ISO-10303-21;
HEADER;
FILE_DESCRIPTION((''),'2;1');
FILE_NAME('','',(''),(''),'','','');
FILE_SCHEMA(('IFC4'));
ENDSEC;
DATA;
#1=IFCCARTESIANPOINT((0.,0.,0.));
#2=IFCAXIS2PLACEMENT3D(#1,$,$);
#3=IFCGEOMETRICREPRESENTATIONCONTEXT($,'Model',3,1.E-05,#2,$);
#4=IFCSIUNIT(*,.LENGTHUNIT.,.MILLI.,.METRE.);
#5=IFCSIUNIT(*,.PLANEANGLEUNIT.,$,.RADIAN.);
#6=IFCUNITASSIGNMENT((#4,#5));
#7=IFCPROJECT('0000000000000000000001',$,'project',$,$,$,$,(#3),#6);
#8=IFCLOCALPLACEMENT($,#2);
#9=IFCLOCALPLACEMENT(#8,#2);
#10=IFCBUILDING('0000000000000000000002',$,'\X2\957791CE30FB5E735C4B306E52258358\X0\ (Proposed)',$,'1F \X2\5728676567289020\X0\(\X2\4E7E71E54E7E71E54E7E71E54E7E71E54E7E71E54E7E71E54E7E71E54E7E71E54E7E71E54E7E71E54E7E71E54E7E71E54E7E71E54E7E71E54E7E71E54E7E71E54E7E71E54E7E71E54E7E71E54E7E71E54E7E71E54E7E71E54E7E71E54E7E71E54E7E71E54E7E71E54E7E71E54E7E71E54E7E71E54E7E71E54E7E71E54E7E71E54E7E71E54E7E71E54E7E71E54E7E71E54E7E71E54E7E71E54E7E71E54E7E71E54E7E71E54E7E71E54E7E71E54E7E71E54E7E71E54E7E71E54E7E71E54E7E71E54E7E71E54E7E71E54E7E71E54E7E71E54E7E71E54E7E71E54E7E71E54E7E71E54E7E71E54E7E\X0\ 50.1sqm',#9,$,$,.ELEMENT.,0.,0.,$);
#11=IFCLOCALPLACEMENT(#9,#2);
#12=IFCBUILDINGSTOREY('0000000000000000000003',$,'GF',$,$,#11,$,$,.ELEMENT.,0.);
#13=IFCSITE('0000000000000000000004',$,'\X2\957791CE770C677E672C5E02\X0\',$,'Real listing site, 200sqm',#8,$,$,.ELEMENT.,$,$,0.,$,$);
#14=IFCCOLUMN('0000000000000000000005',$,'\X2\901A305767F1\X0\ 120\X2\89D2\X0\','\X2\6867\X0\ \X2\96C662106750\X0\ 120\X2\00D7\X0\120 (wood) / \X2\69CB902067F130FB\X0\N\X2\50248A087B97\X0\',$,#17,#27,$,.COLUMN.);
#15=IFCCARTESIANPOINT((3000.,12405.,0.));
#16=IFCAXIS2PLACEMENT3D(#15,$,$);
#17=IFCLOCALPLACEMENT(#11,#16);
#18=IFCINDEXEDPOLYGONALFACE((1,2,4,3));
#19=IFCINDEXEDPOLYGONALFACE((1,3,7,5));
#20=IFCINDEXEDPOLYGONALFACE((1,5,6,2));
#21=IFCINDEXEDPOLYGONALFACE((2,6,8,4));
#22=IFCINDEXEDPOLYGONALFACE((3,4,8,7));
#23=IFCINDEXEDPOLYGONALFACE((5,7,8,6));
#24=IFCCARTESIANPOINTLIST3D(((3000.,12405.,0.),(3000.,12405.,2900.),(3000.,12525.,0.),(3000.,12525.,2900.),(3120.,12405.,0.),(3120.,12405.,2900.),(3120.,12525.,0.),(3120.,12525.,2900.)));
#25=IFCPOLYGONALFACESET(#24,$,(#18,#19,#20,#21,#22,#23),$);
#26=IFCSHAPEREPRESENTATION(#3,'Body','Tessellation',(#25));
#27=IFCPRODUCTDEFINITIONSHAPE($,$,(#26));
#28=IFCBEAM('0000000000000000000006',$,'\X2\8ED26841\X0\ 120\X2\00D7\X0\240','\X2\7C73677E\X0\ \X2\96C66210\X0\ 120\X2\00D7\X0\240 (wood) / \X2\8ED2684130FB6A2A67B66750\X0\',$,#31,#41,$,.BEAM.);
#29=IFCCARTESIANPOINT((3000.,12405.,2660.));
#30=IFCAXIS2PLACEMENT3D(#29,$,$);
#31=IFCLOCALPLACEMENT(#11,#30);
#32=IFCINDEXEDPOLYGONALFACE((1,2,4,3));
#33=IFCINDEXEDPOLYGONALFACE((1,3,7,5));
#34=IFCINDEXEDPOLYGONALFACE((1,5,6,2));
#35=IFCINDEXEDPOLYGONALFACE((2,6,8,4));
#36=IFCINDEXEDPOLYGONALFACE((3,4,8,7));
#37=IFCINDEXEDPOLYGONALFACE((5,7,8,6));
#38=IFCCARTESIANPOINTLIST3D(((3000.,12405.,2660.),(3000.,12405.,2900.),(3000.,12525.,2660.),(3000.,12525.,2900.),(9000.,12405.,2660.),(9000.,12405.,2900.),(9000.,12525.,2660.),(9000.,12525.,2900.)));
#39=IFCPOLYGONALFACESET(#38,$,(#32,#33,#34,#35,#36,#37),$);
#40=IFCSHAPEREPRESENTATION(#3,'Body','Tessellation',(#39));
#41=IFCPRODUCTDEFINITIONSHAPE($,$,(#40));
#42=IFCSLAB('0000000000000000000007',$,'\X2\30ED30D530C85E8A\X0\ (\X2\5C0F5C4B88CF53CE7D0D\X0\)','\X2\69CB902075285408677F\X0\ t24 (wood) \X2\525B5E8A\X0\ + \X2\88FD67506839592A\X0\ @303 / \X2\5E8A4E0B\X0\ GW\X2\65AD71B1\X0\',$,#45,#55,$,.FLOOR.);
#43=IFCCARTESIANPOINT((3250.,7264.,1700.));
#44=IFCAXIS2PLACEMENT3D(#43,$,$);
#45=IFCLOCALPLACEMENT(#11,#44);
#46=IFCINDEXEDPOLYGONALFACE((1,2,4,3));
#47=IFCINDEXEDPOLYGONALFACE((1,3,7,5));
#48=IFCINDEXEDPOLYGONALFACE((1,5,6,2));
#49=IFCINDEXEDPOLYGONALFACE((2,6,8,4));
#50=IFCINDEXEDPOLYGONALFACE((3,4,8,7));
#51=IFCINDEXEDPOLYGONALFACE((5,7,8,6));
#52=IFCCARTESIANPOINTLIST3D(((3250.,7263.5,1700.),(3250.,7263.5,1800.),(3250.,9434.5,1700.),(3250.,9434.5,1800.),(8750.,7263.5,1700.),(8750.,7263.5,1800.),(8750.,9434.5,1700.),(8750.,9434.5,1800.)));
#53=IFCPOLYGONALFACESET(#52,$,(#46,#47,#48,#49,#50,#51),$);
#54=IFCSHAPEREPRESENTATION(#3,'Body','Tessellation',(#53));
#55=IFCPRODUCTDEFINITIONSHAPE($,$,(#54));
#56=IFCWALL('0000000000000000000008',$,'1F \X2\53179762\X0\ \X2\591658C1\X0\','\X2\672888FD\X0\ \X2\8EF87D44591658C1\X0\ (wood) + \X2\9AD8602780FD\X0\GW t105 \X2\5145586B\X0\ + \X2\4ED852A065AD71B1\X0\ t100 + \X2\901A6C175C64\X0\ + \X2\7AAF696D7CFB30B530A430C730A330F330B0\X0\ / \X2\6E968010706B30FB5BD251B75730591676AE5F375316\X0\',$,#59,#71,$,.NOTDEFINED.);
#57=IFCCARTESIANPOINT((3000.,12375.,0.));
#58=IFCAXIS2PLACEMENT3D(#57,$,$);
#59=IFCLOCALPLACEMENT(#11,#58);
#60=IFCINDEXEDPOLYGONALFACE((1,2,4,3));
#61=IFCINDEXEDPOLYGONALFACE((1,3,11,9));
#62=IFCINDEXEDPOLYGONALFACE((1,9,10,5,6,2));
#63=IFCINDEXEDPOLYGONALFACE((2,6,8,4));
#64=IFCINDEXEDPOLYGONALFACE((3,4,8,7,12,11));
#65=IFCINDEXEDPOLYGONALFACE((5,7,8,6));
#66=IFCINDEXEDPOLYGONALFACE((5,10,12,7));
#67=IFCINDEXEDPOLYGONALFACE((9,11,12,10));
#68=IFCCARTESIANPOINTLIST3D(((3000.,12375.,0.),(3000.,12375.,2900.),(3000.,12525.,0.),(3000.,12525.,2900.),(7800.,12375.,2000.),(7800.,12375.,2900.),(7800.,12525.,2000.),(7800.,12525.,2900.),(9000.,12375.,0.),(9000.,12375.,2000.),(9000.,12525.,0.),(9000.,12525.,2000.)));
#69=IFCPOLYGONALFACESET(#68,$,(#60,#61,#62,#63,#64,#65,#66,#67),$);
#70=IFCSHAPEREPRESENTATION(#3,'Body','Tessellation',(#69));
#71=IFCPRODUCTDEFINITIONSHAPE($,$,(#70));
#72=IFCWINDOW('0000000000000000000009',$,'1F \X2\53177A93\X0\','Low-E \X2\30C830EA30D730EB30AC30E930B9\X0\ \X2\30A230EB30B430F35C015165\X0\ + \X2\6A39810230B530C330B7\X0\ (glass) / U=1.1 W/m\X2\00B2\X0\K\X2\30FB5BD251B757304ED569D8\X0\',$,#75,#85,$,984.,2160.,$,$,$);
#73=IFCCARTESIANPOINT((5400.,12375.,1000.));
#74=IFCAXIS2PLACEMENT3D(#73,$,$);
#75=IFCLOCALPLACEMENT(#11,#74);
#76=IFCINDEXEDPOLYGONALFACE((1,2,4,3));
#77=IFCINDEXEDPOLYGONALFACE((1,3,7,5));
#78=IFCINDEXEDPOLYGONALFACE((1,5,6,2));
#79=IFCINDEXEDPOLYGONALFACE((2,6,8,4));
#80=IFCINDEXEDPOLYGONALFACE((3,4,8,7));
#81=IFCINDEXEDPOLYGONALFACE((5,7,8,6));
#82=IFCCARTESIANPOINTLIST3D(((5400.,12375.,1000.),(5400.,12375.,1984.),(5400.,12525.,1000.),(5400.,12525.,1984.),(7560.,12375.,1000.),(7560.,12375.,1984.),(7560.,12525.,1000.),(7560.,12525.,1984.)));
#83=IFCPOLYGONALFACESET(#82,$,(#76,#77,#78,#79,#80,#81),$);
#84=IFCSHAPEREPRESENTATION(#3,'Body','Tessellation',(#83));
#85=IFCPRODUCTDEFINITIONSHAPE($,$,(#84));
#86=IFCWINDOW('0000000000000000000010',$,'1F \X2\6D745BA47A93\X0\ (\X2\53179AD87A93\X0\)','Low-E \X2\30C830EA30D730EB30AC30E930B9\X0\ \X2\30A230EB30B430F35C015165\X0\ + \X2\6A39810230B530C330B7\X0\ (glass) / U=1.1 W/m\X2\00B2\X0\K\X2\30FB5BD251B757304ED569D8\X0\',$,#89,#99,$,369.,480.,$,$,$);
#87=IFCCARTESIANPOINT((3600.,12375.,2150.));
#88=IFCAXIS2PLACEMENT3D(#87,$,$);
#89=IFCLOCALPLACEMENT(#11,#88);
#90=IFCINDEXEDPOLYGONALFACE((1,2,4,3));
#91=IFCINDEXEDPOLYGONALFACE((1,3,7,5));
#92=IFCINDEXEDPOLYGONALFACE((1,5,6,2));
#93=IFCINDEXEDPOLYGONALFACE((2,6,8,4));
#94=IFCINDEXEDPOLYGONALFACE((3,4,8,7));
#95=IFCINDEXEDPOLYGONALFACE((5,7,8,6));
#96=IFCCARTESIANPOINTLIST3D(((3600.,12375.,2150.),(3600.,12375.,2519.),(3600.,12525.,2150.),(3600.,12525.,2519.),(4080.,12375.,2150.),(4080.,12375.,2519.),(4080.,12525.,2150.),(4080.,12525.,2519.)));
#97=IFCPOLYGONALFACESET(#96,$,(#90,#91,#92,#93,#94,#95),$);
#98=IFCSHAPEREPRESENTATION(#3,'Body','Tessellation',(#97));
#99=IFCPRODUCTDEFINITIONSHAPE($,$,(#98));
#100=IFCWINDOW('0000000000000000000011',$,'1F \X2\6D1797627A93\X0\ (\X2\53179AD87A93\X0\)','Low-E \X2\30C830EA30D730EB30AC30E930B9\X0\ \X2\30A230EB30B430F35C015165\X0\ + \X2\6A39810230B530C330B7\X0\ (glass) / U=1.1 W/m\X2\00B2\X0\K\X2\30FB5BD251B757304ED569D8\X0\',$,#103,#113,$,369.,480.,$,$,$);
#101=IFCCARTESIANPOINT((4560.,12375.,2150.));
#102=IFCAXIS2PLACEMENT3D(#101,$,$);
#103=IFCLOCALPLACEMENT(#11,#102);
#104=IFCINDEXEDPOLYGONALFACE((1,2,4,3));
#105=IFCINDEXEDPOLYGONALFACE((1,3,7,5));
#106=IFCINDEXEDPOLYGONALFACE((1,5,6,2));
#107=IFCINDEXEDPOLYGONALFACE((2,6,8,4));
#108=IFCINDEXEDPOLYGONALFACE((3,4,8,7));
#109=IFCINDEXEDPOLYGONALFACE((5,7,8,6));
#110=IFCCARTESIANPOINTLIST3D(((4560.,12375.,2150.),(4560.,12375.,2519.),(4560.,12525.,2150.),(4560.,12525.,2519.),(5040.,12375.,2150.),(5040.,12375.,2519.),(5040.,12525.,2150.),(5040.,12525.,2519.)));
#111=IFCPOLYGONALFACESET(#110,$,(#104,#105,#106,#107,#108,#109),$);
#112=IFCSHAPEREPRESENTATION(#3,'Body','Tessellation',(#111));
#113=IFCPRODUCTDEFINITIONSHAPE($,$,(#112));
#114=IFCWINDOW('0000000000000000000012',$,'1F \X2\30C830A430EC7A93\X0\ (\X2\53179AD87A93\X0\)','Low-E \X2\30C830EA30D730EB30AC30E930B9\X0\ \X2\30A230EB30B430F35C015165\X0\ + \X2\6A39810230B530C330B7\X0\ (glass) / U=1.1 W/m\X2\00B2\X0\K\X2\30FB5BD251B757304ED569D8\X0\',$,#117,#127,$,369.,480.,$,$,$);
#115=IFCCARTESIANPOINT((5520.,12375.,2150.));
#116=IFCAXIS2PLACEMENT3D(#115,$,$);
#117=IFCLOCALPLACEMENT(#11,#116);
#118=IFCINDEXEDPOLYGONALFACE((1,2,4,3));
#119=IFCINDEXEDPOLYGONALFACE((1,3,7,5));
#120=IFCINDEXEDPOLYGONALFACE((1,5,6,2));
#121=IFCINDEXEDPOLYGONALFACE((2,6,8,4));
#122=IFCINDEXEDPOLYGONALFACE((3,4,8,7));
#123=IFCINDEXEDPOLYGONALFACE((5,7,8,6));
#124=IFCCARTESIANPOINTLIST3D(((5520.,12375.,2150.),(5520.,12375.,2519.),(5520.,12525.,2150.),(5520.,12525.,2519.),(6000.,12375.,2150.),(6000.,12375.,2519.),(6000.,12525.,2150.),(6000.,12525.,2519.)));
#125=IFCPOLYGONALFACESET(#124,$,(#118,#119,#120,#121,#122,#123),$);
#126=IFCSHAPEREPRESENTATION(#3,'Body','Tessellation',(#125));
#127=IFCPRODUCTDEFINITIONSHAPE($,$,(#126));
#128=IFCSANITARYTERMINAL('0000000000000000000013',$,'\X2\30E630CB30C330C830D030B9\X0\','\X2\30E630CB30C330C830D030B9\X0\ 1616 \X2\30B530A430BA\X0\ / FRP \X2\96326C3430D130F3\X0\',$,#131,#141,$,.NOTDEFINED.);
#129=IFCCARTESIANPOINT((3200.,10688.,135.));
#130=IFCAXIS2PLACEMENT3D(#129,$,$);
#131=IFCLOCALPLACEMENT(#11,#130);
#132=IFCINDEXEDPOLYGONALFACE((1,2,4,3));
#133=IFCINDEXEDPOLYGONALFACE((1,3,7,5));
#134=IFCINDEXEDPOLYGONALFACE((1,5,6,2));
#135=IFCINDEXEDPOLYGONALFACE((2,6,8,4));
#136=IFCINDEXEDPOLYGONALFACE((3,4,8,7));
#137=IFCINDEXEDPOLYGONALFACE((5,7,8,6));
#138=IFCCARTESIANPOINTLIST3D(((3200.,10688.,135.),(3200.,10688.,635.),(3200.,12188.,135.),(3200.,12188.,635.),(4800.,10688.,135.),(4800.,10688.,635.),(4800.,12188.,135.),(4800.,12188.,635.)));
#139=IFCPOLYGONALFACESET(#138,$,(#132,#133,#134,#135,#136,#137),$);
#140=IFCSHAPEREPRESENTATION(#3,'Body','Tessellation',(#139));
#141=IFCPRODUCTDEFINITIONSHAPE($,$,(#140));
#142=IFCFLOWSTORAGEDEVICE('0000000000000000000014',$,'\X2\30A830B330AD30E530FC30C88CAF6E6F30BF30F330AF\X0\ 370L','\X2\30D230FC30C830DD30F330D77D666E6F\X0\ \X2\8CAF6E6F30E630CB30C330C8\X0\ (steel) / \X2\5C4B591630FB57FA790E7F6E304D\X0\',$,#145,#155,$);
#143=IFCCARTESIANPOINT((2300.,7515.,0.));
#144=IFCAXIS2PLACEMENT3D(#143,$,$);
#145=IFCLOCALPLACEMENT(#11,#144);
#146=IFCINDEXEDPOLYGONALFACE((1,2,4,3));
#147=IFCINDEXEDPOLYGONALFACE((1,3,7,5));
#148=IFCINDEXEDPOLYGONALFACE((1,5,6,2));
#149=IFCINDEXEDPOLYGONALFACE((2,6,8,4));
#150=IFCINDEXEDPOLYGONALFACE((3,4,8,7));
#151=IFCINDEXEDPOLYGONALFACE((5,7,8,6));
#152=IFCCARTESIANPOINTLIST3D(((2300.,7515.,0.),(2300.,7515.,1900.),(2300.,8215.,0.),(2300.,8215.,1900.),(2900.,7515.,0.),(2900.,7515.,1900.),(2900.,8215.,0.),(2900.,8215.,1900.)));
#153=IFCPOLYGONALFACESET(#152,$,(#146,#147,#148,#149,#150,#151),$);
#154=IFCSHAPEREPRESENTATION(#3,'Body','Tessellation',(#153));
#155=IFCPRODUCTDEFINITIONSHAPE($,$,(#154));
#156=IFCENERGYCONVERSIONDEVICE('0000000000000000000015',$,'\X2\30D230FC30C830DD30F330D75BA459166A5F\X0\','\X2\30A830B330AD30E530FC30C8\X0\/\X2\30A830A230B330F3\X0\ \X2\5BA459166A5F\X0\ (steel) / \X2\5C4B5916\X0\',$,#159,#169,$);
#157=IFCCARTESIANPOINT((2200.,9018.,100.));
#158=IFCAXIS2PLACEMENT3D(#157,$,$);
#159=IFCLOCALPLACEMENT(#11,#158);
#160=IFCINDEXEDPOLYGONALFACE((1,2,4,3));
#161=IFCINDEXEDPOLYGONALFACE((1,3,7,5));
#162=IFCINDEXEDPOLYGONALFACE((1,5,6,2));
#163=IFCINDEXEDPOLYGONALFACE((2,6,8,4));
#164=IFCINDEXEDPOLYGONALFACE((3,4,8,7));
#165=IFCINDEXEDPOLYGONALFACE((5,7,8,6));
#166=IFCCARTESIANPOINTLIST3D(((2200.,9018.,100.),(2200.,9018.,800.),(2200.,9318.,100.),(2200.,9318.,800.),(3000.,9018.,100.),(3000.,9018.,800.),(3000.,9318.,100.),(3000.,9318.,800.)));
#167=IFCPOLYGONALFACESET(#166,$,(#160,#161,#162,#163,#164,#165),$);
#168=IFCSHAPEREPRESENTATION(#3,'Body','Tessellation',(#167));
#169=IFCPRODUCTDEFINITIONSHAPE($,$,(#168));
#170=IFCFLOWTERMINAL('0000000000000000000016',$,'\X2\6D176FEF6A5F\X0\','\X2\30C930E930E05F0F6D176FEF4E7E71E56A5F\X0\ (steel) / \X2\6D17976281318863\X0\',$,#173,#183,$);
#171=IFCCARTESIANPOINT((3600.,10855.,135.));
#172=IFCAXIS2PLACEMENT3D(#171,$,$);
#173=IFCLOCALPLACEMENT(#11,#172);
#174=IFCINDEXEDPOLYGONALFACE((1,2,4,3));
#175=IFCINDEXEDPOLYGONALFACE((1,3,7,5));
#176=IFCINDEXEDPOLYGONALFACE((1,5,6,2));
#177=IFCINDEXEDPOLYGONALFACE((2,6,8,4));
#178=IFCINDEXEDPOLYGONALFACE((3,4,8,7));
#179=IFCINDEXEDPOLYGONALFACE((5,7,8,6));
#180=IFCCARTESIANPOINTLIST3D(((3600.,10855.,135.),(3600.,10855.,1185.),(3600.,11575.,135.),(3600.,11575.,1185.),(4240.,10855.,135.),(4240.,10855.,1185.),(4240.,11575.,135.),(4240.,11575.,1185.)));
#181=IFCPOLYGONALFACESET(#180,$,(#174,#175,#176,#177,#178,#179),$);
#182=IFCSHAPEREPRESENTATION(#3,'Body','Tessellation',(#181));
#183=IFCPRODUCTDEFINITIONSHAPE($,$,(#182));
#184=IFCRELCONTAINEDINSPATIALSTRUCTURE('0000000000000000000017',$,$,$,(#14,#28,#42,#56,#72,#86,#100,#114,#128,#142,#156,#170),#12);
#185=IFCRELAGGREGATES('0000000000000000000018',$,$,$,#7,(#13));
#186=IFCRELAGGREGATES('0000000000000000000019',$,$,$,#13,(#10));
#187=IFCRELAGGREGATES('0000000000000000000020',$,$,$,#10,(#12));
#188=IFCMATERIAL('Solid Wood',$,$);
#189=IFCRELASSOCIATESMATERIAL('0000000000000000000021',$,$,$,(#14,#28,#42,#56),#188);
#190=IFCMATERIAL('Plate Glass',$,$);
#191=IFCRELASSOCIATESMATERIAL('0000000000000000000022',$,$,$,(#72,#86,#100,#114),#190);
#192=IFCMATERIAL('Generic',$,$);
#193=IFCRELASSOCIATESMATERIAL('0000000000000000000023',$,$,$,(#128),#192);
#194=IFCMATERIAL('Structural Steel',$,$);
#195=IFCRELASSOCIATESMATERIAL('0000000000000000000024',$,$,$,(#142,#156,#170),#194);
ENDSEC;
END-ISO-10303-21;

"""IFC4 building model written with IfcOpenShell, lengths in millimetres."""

from ifc_helpers import new_model, si_unit, frame, frame_2d, origin, place, context, project, spatial, rectangle, extrude, material, element, fill, save


model = new_model("IFC4")

# Units and contexts
model_context = context("Model", 3, precision=1e-05, world=origin())
ifc_project = project(units=[si_unit("LENGTHUNIT", "METRE", prefix="MILLI"), si_unit("PLANEANGLEUNIT", "RADIAN")], contexts=[model_context])

# Site, building, storey
site_placement = place(None, origin())
site = spatial("IfcSite", under=ifc_project, at=site_placement, Name="長野県松本市", ObjectType="Real listing site, 200sqm", CompositionType="ELEMENT", RefElevation=0.0)
building_placement = place(site_placement, origin())
building = spatial("IfcBuilding", under=site, at=building_placement, Name="長野・平屋の別荘 (Proposed)", ObjectType="1F 在来木造(乾燥乾燥乾燥乾燥乾燥乾燥乾燥乾燥乾燥乾燥乾燥乾燥乾燥乾燥乾燥乾燥乾燥乾燥乾燥乾燥乾燥乾燥乾燥乾燥乾燥乾燥乾燥乾燥乾燥乾燥乾燥乾燥乾燥乾燥乾燥乾燥乾燥乾燥乾燥乾燥乾燥乾燥乾燥乾燥乾燥乾燥乾燥乾燥乾燥乾燥乾燥乾燥乾燥乾燥乾燥乾燥乾燥乾 50.1sqm", CompositionType="ELEMENT", ElevationOfRefHeight=0.0, ElevationOfTerrain=0.0)
storey_placement = place(building_placement, origin())
storey = spatial("IfcBuildingStorey", under=building, at=storey_placement, Name="GF", CompositionType="ELEMENT", Elevation=0.0)

# Column
ifc_material_1 = material(Name="Solid Wood")
column_1_placement = place(storey_placement, frame((3000.0, 12405.0, 0.0)))
element("IfcColumn", 1, at=column_1_placement, inside=storey, material=ifc_material_1, Name="通し柱 120角", Description="桧 集成材 120×120 (wood) / 構造柱・N値計算", PredefinedType="COLUMN", context=model_context, shape_type="SweptSolid", body=[
    extrude(rectangle(XDim=120.0, YDim=120.0, at=frame_2d((60.0, 60.0))), frame((3000.0, 12405.0, 0.0)), (0.0, 0.0, 1.0), 2900.0),
])

# Beam
beam_1_placement = place(storey_placement, frame((3000.0, 12405.0, 2660.0)))
element("IfcBeam", 2, at=beam_1_placement, inside=storey, material=ifc_material_1, Name="軒桁 120×240", Description="米松 集成 120×240 (wood) / 軒桁・横架材", PredefinedType="BEAM", context=model_context, shape_type="SweptSolid", body=[
    extrude(rectangle(XDim=6000.0, YDim=120.0, at=frame_2d((3000.0, 60.0))), frame((3000.0, 12405.0, 2660.0)), (0.0, 0.0, 1.0), 240.0),
])

# Slab
slab_placement = place(storey_placement, frame((3250.0, 7264.0, 1700.0)))
element("IfcSlab", 3, at=slab_placement, inside=storey, material=ifc_material_1, Name="ロフト床 (小屋裏収納)", Description="構造用合板 t24 (wood) 剛床 + 製材根太 @303 / 床下 GW断熱", PredefinedType="FLOOR", context=model_context, shape_type="SweptSolid", body=[
    extrude(rectangle(XDim=5500.0, YDim=2171.0, at=frame_2d((2750.0, 1085.0))), frame((3250.0, 7264.0, 1700.0)), (0.0, 0.0, 1.0), 100.0),
])

# Wall, openings, windows
wall_1_placement = place(storey_placement, frame((3000.0, 12375.0, 0.0)))
wall_1 = element("IfcWall", 4, at=wall_1_placement, inside=storey, material=ifc_material_1, Name="1F 北面 外壁", Description="木製 軸組外壁 (wood) + 高性能GW t105 充填 + 付加断熱 t100 + 通気層 + 窯業系サイディング / 準耐火・寒冷地外皮強化", PredefinedType="NOTDEFINED", context=model_context, shape_type="SweptSolid", body=[
    extrude(rectangle(XDim=6000.0, YDim=150.0, at=frame_2d((3000.0, 75.0))), frame((3000.0, 12375.0, 0.0)), (0.0, 0.0, 1.0), 2900.0),
])
opening_1_placement = place(storey_placement, frame((5400.0, 12375.0, 1000.0)))
opening_1 = element("IfcOpeningElement", 5, at=opening_1_placement, cuts=wall_1, PredefinedType="NOTDEFINED", context=model_context, shape_type="SweptSolid", body=[
    extrude(rectangle(XDim=2160.0, YDim=150.0, at=frame_2d((1080.0, 75.0))), frame((5400.0, 12375.0, 1000.0)), (0.0, 0.0, 1.0), 984.0),
])
opening_2_placement = place(storey_placement, frame((3600.0, 12375.0, 2150.0)))
opening_2 = element("IfcOpeningElement", 6, at=opening_2_placement, cuts=wall_1, PredefinedType="NOTDEFINED", context=model_context, shape_type="SweptSolid", body=[
    extrude(rectangle(XDim=480.0, YDim=150.0, at=frame_2d((240.0, 75.0))), frame((3600.0, 12375.0, 2150.0)), (0.0, 0.0, 1.0), 369.0),
])
opening_3_placement = place(storey_placement, frame((4560.0, 12375.0, 2150.0)))
opening_3 = element("IfcOpeningElement", 7, at=opening_3_placement, cuts=wall_1, PredefinedType="NOTDEFINED", context=model_context, shape_type="SweptSolid", body=[
    extrude(rectangle(XDim=480.0, YDim=150.0, at=frame_2d((240.0, 75.0))), frame((4560.0, 12375.0, 2150.0)), (0.0, 0.0, 1.0), 369.0),
])
opening_4_placement = place(storey_placement, frame((5520.0, 12375.0, 2150.0)))
opening_4 = element("IfcOpeningElement", 8, at=opening_4_placement, cuts=wall_1, PredefinedType="NOTDEFINED", context=model_context, shape_type="SweptSolid", body=[
    extrude(rectangle(XDim=480.0, YDim=150.0, at=frame_2d((240.0, 75.0))), frame((5520.0, 12375.0, 2150.0)), (0.0, 0.0, 1.0), 369.0),
])
ifc_material_2 = material(Name="Plate Glass")
window_1_placement = place(storey_placement, frame((5400.0, 12375.0, 1000.0)))
window_1 = element("IfcWindow", 9, at=window_1_placement, inside=storey, material=ifc_material_2, Name="1F 北窓", Description="Low-E トリプルガラス アルゴン封入 + 樹脂サッシ (glass) / U=1.1 W/m²K・寒冷地仕様", OverallHeight=984.0, OverallWidth=2160.0, context=model_context, shape_type="SweptSolid", body=[
    extrude(rectangle(XDim=2160.0, YDim=150.0, at=frame_2d((1080.0, 75.0))), frame((5400.0, 12375.0, 1000.0)), (0.0, 0.0, 1.0), 984.0),
])
fill(opening_1, window_1)
window_2_placement = place(storey_placement, frame((3600.0, 12375.0, 2150.0)))
window_2 = element("IfcWindow", 10, at=window_2_placement, inside=storey, material=ifc_material_2, Name="1F 浴室窓 (北高窓)", Description="Low-E トリプルガラス アルゴン封入 + 樹脂サッシ (glass) / U=1.1 W/m²K・寒冷地仕様", OverallHeight=369.0, OverallWidth=480.0, context=model_context, shape_type="SweptSolid", body=[
    extrude(rectangle(XDim=480.0, YDim=150.0, at=frame_2d((240.0, 75.0))), frame((3600.0, 12375.0, 2150.0)), (0.0, 0.0, 1.0), 369.0),
])
fill(opening_2, window_2)
window_3_placement = place(storey_placement, frame((4560.0, 12375.0, 2150.0)))
window_3 = element("IfcWindow", 11, at=window_3_placement, inside=storey, material=ifc_material_2, Name="1F 洗面窓 (北高窓)", Description="Low-E トリプルガラス アルゴン封入 + 樹脂サッシ (glass) / U=1.1 W/m²K・寒冷地仕様", OverallHeight=369.0, OverallWidth=480.0, context=model_context, shape_type="SweptSolid", body=[
    extrude(rectangle(XDim=480.0, YDim=150.0, at=frame_2d((240.0, 75.0))), frame((4560.0, 12375.0, 2150.0)), (0.0, 0.0, 1.0), 369.0),
])
fill(opening_3, window_3)
window_4_placement = place(storey_placement, frame((5520.0, 12375.0, 2150.0)))
window_4 = element("IfcWindow", 12, at=window_4_placement, inside=storey, material=ifc_material_2, Name="1F トイレ窓 (北高窓)", Description="Low-E トリプルガラス アルゴン封入 + 樹脂サッシ (glass) / U=1.1 W/m²K・寒冷地仕様", OverallHeight=369.0, OverallWidth=480.0, context=model_context, shape_type="SweptSolid", body=[
    extrude(rectangle(XDim=480.0, YDim=150.0, at=frame_2d((240.0, 75.0))), frame((5520.0, 12375.0, 2150.0)), (0.0, 0.0, 1.0), 369.0),
])
fill(opening_4, window_4)

# Sanitary terminal
ifc_material_3 = material(Name="Generic")
sanitary_terminal_placement = place(storey_placement, frame((3200.0, 10688.0, 135.0)))
element("IfcSanitaryTerminal", 13, at=sanitary_terminal_placement, inside=storey, material=ifc_material_3, Name="ユニットバス", Description="ユニットバス 1616 サイズ / FRP 防水パン", PredefinedType="NOTDEFINED", context=model_context, shape_type="SweptSolid", body=[
    extrude(rectangle(XDim=1600.0, YDim=1500.0, at=frame_2d((800.0, 750.0))), frame((3200.0, 10688.0, 135.0)), (0.0, 0.0, 1.0), 500.0),
])

# Flow storage device
ifc_material_4 = material(Name="Structural Steel")
flow_storage_device_placement = place(storey_placement, frame((2300.0, 7515.0, 0.0)))
element("IfcFlowStorageDevice", 14, at=flow_storage_device_placement, inside=storey, material=ifc_material_4, Name="エコキュート貯湯タンク 370L", Description="ヒートポンプ給湯 貯湯ユニット (steel) / 屋外・基礎置き", context=model_context, shape_type="SweptSolid", body=[
    extrude(rectangle(XDim=600.0, YDim=700.0, at=frame_2d((300.0, 350.0))), frame((2300.0, 7515.0, 0.0)), (0.0, 0.0, 1.0), 1900.0),
])

# Energy conversion device
energy_conversion_device_placement = place(storey_placement, frame((2200.0, 9018.0, 100.0)))
element("IfcEnergyConversionDevice", 15, at=energy_conversion_device_placement, inside=storey, material=ifc_material_4, Name="ヒートポンプ室外機", Description="エコキュート/エアコン 室外機 (steel) / 屋外", context=model_context, shape_type="SweptSolid", body=[
    extrude(rectangle(XDim=800.0, YDim=300.0, at=frame_2d((400.0, 150.0))), frame((2200.0, 9018.0, 100.0)), (0.0, 0.0, 1.0), 700.0),
])

# Flow terminal
flow_terminal_placement = place(storey_placement, frame((3600.0, 10855.0, 135.0)))
element("IfcFlowTerminal", 16, at=flow_terminal_placement, inside=storey, material=ifc_material_4, Name="洗濯機", Description="ドラム式洗濯乾燥機 (steel) / 洗面脱衣", context=model_context, shape_type="SweptSolid", body=[
    extrude(rectangle(XDim=640.0, YDim=720.0, at=frame_2d((320.0, 360.0))), frame((3600.0, 10855.0, 135.0)), (0.0, 0.0, 1.0), 1050.0),
])

save(model, "model.ifc")
